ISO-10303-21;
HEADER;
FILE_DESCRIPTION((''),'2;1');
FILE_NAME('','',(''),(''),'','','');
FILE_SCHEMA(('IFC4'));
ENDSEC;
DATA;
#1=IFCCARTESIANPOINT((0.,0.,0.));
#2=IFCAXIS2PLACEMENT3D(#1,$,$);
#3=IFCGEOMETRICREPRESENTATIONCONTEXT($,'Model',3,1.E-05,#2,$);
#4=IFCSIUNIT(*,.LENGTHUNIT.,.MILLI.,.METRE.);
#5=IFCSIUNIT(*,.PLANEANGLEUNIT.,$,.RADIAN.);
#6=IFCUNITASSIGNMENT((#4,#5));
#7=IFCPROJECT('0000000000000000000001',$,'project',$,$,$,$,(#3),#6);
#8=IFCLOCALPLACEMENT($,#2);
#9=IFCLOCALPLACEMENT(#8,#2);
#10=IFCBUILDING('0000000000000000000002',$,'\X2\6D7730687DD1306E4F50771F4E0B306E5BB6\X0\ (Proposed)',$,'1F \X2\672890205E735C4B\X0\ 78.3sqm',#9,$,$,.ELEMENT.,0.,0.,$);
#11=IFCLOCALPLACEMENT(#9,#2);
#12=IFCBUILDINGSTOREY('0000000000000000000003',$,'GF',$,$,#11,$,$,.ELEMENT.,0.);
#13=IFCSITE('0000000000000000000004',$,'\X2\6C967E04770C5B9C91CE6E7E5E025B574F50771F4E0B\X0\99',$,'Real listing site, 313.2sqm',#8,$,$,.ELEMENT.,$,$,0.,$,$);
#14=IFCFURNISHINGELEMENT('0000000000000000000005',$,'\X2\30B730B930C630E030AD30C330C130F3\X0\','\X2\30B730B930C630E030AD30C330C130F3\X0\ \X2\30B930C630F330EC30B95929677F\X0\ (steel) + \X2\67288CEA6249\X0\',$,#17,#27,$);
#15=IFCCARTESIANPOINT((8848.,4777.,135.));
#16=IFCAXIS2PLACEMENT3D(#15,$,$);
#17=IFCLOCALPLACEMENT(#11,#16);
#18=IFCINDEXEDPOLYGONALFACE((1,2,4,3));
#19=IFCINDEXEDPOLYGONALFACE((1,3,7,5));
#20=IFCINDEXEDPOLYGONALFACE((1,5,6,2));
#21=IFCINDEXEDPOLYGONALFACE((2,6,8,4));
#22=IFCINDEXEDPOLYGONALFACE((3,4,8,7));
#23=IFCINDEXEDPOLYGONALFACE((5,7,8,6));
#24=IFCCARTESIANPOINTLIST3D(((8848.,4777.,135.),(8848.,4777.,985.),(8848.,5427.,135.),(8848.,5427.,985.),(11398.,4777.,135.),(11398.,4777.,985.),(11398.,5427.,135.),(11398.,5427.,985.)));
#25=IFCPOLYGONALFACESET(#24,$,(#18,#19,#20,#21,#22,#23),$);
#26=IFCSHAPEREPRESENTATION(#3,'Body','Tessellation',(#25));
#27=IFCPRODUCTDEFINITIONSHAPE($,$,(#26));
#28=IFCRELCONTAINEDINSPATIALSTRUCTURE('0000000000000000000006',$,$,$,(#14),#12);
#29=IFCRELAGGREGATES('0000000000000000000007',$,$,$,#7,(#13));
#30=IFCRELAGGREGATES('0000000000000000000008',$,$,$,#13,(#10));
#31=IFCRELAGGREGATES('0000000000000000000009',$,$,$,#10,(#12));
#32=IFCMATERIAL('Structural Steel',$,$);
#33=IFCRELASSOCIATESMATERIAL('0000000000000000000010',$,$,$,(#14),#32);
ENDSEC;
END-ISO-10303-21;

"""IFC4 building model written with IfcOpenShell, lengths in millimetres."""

from ifc_helpers import new_model, si_unit, frame, frame_2d, origin, place, context, project, spatial, rectangle, extrude, material, element, save


model = new_model("IFC4")

# Units and contexts
model_context = context("Model", 3, precision=1e-05, world=origin())
ifc_project = project(units=[si_unit("LENGTHUNIT", "METRE", prefix="MILLI"), si_unit("PLANEANGLEUNIT", "RADIAN")], contexts=[model_context])

# Site, building, storey
site_placement = place(None, origin())
site = spatial("IfcSite", under=ifc_project, at=site_placement, Name="沖縄県宜野湾市字佐真下99", ObjectType="Real listing site, 313.2sqm", CompositionType="ELEMENT", RefElevation=0.0)
building_placement = place(site_placement, origin())
building = spatial("IfcBuilding", under=site, at=building_placement, Name="海と緑の佐真下の家 (Proposed)", ObjectType="1F 木造平屋 78.3sqm", CompositionType="ELEMENT", ElevationOfRefHeight=0.0, ElevationOfTerrain=0.0)
storey_placement = place(building_placement, origin())
storey = spatial("IfcBuildingStorey", under=building, at=storey_placement, Name="GF", CompositionType="ELEMENT", Elevation=0.0)

# Shared definitions
ifc_material_1 = material(Name="Structural Steel")

# Furnishing element
furnishing_1_placement = place(storey_placement, frame((8848.0, 4777.0, 135.0)))
element("IfcFurnishingElement", 1, at=furnishing_1_placement, inside=storey, material=ifc_material_1, Name="システムキッチン", Description="システムキッチン ステンレス天板 (steel) + 木質扉", context=model_context, shape_type="SweptSolid", body=[
    extrude(rectangle(XDim=2550.0, YDim=650.0, at=frame_2d((1275.0, 325.0))), frame((8848.0, 4777.0, 135.0)), (0.0, 0.0, 1.0), 850.0),
])

save(model, "model.ifc")
